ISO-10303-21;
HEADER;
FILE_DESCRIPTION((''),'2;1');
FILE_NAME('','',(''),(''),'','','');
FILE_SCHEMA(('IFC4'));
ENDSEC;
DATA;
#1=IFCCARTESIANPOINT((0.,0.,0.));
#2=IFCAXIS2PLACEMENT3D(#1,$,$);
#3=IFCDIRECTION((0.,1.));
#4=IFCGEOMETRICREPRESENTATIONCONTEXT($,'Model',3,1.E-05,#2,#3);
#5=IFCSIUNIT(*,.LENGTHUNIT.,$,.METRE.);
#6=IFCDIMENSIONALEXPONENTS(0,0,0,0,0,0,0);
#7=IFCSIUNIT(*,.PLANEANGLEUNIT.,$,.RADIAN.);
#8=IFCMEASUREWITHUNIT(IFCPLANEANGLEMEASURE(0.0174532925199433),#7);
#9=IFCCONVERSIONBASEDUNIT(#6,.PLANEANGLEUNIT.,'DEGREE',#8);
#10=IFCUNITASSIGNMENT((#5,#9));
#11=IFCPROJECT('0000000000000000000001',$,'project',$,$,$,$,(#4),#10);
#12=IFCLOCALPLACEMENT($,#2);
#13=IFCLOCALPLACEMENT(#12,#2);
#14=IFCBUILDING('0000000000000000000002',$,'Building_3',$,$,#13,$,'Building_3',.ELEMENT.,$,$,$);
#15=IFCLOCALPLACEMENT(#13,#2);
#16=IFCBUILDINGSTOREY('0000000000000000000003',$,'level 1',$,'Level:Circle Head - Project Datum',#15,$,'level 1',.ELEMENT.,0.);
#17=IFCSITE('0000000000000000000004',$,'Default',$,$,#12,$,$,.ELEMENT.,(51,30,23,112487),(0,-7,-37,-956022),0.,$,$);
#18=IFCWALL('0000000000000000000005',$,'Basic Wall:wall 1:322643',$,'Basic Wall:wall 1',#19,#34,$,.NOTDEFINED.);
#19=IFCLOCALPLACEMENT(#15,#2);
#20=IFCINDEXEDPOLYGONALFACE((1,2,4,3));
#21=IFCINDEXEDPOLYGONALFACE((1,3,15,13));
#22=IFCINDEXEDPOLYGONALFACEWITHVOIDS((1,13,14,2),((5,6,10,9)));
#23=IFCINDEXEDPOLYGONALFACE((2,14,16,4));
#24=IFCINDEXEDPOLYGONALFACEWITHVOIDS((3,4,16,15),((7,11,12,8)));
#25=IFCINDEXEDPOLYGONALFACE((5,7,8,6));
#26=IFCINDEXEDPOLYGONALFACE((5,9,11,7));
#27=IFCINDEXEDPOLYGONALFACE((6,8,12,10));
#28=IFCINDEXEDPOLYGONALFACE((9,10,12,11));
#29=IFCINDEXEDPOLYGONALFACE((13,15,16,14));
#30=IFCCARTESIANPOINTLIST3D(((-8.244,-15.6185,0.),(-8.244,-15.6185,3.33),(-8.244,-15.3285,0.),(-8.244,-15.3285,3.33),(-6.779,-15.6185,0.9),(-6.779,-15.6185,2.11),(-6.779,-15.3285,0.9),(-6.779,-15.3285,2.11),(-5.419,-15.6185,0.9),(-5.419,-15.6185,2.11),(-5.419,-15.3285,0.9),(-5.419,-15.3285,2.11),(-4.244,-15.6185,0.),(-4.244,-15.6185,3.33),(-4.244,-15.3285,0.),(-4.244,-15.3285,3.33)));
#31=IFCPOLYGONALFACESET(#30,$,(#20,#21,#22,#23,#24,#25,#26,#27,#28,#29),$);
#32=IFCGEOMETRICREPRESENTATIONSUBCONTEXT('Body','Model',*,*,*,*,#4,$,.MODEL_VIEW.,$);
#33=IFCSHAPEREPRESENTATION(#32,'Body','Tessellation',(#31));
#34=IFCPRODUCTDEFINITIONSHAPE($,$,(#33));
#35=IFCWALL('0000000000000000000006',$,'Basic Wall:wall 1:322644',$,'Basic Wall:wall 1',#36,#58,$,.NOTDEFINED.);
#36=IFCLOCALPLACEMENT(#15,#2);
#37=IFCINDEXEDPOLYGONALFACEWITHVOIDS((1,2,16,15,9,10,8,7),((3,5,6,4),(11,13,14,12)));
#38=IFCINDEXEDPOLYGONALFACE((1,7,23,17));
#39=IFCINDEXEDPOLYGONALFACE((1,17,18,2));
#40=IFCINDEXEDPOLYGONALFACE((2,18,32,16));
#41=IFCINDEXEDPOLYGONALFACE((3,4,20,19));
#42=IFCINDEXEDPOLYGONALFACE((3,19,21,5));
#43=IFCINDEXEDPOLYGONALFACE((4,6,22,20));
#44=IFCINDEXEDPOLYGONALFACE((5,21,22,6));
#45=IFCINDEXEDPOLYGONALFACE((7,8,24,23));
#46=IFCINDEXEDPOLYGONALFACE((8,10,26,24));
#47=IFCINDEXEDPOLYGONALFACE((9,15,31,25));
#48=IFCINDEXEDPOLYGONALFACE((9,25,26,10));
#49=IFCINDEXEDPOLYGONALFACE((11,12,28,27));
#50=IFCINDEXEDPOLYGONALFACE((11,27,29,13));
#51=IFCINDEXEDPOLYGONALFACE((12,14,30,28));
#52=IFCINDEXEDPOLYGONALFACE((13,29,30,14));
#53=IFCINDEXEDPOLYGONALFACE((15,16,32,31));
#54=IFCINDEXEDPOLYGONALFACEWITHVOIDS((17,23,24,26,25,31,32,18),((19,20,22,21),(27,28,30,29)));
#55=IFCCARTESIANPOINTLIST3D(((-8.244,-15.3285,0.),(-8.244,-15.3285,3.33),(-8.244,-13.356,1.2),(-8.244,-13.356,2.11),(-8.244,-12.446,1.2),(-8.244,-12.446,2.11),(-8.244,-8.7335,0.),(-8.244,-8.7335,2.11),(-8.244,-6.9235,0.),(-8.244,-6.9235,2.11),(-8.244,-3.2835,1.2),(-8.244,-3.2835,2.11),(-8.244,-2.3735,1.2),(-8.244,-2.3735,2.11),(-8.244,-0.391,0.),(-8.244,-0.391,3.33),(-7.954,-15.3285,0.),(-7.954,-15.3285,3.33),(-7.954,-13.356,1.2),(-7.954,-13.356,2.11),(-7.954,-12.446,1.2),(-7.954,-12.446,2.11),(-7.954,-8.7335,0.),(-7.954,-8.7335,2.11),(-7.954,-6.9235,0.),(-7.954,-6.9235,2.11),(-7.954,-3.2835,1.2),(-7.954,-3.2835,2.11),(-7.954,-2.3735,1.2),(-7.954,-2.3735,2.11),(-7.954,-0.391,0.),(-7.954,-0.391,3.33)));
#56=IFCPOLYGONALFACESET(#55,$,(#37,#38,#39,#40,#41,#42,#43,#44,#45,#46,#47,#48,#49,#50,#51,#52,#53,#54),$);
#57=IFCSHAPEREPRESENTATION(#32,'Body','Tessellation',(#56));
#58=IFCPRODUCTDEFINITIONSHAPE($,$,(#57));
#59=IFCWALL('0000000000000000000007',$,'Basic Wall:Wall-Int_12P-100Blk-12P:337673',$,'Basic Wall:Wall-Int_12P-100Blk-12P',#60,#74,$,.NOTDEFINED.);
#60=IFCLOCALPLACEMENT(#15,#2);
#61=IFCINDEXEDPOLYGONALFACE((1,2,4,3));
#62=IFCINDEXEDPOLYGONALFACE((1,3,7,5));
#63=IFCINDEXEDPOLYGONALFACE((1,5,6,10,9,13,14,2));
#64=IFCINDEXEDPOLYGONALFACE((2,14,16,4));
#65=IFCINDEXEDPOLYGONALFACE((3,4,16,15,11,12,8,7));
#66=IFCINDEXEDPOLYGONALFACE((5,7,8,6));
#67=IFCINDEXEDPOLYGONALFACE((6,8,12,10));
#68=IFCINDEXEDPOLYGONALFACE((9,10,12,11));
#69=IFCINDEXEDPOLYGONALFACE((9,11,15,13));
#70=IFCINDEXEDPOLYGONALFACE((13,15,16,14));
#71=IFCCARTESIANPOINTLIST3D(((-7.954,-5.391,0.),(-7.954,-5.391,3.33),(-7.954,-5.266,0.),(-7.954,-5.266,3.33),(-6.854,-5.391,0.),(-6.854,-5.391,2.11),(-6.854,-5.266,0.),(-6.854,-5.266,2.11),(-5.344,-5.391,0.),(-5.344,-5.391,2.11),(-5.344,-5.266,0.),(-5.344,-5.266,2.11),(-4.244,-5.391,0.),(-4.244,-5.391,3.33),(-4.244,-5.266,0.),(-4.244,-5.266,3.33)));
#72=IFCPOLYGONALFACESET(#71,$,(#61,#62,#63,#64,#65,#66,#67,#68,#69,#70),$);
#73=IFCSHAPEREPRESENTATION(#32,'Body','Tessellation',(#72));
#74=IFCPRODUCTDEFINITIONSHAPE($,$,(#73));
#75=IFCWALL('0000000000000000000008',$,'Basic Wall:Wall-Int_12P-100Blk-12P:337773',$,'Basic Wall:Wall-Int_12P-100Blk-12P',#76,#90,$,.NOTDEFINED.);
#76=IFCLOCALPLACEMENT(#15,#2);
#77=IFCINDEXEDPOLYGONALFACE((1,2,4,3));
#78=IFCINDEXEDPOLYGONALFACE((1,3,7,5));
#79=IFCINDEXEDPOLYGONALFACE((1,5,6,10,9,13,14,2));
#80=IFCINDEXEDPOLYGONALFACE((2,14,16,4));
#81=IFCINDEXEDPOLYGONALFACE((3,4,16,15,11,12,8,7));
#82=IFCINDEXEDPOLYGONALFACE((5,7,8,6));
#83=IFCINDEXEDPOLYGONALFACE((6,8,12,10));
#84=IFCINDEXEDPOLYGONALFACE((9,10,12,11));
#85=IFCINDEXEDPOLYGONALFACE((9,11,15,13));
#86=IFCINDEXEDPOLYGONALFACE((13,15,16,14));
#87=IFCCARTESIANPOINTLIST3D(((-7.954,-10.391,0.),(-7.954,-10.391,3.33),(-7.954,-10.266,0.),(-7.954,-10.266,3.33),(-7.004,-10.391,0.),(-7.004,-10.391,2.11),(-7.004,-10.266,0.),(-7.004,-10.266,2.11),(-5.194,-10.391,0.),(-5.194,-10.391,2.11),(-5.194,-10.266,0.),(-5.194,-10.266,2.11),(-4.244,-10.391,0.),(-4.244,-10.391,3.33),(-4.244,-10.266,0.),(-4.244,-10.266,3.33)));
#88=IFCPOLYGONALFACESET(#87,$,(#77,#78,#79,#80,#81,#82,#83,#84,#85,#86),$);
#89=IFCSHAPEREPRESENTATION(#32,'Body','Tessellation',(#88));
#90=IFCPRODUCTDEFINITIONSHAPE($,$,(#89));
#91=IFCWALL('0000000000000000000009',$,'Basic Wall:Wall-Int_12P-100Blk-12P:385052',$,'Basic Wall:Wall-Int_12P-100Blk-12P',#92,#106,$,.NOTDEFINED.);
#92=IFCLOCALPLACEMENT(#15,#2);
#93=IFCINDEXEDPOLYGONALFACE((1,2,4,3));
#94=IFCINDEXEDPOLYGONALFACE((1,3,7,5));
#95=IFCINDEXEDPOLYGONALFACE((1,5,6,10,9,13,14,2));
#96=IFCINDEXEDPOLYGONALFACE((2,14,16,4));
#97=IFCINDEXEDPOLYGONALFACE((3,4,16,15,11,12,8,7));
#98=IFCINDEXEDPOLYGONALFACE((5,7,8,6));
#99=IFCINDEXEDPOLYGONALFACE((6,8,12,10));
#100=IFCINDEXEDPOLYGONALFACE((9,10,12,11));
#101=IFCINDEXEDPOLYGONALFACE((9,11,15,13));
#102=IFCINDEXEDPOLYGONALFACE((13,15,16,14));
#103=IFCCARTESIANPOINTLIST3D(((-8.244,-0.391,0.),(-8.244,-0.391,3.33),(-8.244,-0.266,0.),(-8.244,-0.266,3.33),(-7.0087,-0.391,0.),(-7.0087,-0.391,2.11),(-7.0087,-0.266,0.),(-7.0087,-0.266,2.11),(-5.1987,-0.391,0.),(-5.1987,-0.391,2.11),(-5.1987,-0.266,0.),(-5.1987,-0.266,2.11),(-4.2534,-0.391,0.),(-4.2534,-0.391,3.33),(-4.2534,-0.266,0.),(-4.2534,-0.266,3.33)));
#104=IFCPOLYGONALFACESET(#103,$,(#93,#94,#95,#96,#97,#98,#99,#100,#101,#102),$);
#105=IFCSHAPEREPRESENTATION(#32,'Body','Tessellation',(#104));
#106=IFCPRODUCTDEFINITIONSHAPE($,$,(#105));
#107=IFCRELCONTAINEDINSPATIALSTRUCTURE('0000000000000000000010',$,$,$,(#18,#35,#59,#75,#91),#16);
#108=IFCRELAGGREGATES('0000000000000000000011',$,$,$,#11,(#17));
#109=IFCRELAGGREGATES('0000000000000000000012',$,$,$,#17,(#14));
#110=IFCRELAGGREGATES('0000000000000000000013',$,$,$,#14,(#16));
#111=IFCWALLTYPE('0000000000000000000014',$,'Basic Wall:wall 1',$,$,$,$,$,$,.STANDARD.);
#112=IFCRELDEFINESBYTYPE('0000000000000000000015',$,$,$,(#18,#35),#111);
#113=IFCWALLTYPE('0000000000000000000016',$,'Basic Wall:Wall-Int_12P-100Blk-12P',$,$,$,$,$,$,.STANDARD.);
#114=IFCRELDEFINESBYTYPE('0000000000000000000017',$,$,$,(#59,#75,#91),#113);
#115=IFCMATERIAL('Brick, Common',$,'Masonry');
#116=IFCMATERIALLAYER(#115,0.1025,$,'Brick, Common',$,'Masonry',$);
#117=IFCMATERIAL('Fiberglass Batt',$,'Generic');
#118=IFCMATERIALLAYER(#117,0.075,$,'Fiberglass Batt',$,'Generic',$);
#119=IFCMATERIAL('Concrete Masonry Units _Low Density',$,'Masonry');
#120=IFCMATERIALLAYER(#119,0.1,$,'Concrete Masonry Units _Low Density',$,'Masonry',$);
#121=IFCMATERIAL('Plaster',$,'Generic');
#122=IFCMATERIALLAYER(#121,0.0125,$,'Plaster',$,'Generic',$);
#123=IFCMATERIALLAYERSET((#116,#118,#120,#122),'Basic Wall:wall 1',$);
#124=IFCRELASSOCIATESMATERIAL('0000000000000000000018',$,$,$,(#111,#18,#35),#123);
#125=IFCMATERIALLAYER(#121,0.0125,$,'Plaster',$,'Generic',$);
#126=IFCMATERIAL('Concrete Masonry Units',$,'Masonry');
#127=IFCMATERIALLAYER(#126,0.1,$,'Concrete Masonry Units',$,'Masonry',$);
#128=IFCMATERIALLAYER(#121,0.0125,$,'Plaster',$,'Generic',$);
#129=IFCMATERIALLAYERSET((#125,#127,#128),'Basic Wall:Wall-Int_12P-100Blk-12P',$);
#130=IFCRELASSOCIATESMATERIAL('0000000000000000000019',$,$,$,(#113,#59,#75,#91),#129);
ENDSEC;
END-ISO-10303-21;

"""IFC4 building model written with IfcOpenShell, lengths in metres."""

from ifc_helpers import new_model, entity, si_unit, converted_unit, direction, frame, frame_2d, origin, place, context, subcontext, project, spatial, polyline, rectangle, extrude, clip, bounded_halfspace, material, layer, layer_set, layer_usage, type_object, element, save


model = new_model("IFC4")

# Units and contexts
model_context = context("Model", 3, precision=1e-05, world=origin(), true_north=direction((0.0, 1.0)))
body_context = subcontext(model_context, "Body", "Model", "MODEL_VIEW")
ifc_project = project(units=[si_unit("LENGTHUNIT", "METRE"), converted_unit("PLANEANGLEUNIT", "DEGREE", entity("IfcPlaneAngleMeasure", 0.0174532925199433), si_unit("PLANEANGLEUNIT", "RADIAN"), dimensions=[0, 0, 0, 0, 0, 0, 0])], contexts=[model_context])

# Site, building, storey
site_placement = place(None, origin())
site = spatial("IfcSite", under=ifc_project, at=site_placement, Name="Default", CompositionType="ELEMENT", RefLatitude=(51, 30, 23, 112487), RefLongitude=(0, -7, -37, -956022), RefElevation=0.0)
building_placement = place(site_placement, origin())
building = spatial("IfcBuilding", under=site, at=building_placement, Name="Building_3", LongName="Building_3", CompositionType="ELEMENT")
storey_placement = place(building_placement, origin())
storey = spatial("IfcBuildingStorey", under=building, at=storey_placement, Name="level 1", ObjectType="Level:Circle Head - Project Datum", LongName="level 1", CompositionType="ELEMENT", Elevation=0.0)

# Shared definitions
ifc_material_1 = material(Name="Brick, Common", Category="Masonry")
ifc_layer_1 = layer(ifc_material_1, 0.1025, Name="Brick, Common", Category="Masonry")
ifc_material_2 = material(Name="Fiberglass Batt", Category="Generic")
ifc_layer_2 = layer(ifc_material_2, 0.075, Name="Fiberglass Batt", Category="Generic")
ifc_material_3 = material(Name="Concrete Masonry Units _Low Density", Category="Masonry")
ifc_layer_3 = layer(ifc_material_3, 0.1, Name="Concrete Masonry Units _Low Density", Category="Masonry")
ifc_material_4 = material(Name="Plaster", Category="Generic")
ifc_layer_4 = layer(ifc_material_4, 0.0125, Name="Plaster", Category="Generic")
ifc_layer_set_1 = layer_set([ifc_layer_1, ifc_layer_2, ifc_layer_3, ifc_layer_4], Name="Basic Wall:wall 1")
wall_type_1 = type_object("IfcWallType", Name="Basic Wall:wall 1", PredefinedType="STANDARD", material=ifc_layer_set_1)

# Wall, opening
ifc_layer_usage_1 = layer_usage(ifc_layer_set_1, "AXIS2", "NEGATIVE", 0.145)
wall_1_placement = place(storey_placement, frame((-4.244, -15.4735, 0.0), z_axis=(0.0, 0.0, 1.0), x_axis=(-1.0, 0.0, 0.0)))
wall_1 = element("IfcWall", 1, at=wall_1_placement, inside=storey, type_object=wall_type_1, material=ifc_layer_usage_1, Name="Basic Wall:wall 1:322643", ObjectType="Basic Wall:wall 1", PredefinedType="NOTDEFINED", context=body_context, shape_type="Clipping", body=[
    clip(extrude(rectangle(XDim=4.0, YDim=0.29, at=frame_2d((2.0, 0.0), x_axis=(-1.0, 0.0))), origin(), (0.0, 0.0, 1.0), 3.33), bounded_halfspace(frame((0.0, -0.145, 3.33), z_axis=(0.0, 0.0, -1.0), x_axis=(0.0, -1.0, 0.0)), True, frame((0.0, -0.145, 3.33)), polyline([(0.0, 0.0), (3.71, 0.0), (4.0, 0.0), (4.0, 0.29), (0.0, 0.29), (0.0, 0.0)]))),
])
opening_1_placement = place(wall_1_placement, frame((1.175, -0.145, 0.9)))
element("IfcOpeningElement", 2, at=opening_1_placement, cuts=wall_1, PredefinedType="OPENING", context=body_context, shape_type="SweptSolid", body=[
    extrude(rectangle(XDim=1.21, YDim=1.36, at=frame_2d((0.605, 0.68), x_axis=(-1.0, 0.0))), frame((0.0, 0.0, 0.0), z_axis=(0.0, 1.0, 0.0), x_axis=(0.0, 0.0, 1.0)), (0.0, 0.0, 1.0), 0.29),
])

# Wall, openings
ifc_layer_usage_2 = layer_usage(ifc_layer_set_1, "AXIS2", "NEGATIVE", 0.145)
wall_2_placement = place(storey_placement, frame((-8.099, -15.3285, 0.0), z_axis=(0.0, 0.0, 1.0), x_axis=(0.0, 1.0, 0.0)))
wall_2 = element("IfcWall", 3, at=wall_2_placement, inside=storey, type_object=wall_type_1, material=ifc_layer_usage_2, Name="Basic Wall:wall 1:322644", ObjectType="Basic Wall:wall 1", PredefinedType="NOTDEFINED", context=body_context, shape_type="Clipping", body=[
    clip(extrude(rectangle(XDim=14.9375, YDim=0.29, at=frame_2d((7.4688, 0.0), x_axis=(1.0, 0.0))), origin(), (0.0, 0.0, 1.0), 3.33), bounded_halfspace(frame((0.0, -0.145, 3.33), z_axis=(0.0, 0.0, -1.0), x_axis=(1.0, 0.0, 0.0)), True, frame((0.0, -0.145, 3.33)), polyline([(0.0, 0.0), (4.9375, 0.0), (5.0625, 0.0), (9.9375, 0.0), (10.0625, 0.0), (14.9375, 0.0), (14.9375, 0.29), (0.0, 0.29), (0.0, 0.0)]))),
])
opening_2_placement = place(wall_2_placement, frame((8.405, 0.145, 0.0)))
element("IfcOpeningElement", 4, at=opening_2_placement, cuts=wall_2, PredefinedType="OPENING", context=body_context, shape_type="SweptSolid", body=[
    extrude(rectangle(XDim=2.11, YDim=1.81, at=frame_2d((1.055, 0.905), x_axis=(-1.0, 0.0))), frame((0.0, 0.0, 0.0), z_axis=(0.0, -1.0, 0.0), x_axis=(0.0, 0.0, 1.0)), (0.0, 0.0, 1.0), 0.29),
])
opening_3_placement = place(wall_2_placement, frame((1.9725, -0.145, 1.2)))
element("IfcOpeningElement", 5, at=opening_3_placement, cuts=wall_2, PredefinedType="OPENING", context=body_context, shape_type="SweptSolid", body=[
    extrude(rectangle(XDim=0.91, YDim=0.91, at=frame_2d((0.455, 0.455), x_axis=(-1.0, 0.0))), frame((0.0, 0.0, 0.0), z_axis=(0.0, 1.0, 0.0), x_axis=(0.0, 0.0, 1.0)), (0.0, 0.0, 1.0), 0.29),
])
opening_4_placement = place(wall_2_placement, frame((12.045, -0.145, 1.2)))
element("IfcOpeningElement", 6, at=opening_4_placement, cuts=wall_2, PredefinedType="OPENING", context=body_context, shape_type="SweptSolid", body=[
    extrude(rectangle(XDim=0.91, YDim=0.91, at=frame_2d((0.455, 0.455), x_axis=(-1.0, 0.0))), frame((0.0, 0.0, 0.0), z_axis=(0.0, 1.0, 0.0), x_axis=(0.0, 0.0, 1.0)), (0.0, 0.0, 1.0), 0.29),
])

# Walls, openings
ifc_layer_5 = layer(ifc_material_4, 0.0125, Name="Plaster", Category="Generic")
ifc_material_5 = material(Name="Concrete Masonry Units", Category="Masonry")
ifc_layer_6 = layer(ifc_material_5, 0.1, Name="Concrete Masonry Units", Category="Masonry")
ifc_layer_7 = layer(ifc_material_4, 0.0125, Name="Plaster", Category="Generic")
ifc_layer_set_2 = layer_set([ifc_layer_5, ifc_layer_6, ifc_layer_7], Name="Basic Wall:Wall-Int_12P-100Blk-12P")
ifc_layer_usage_3 = layer_usage(ifc_layer_set_2, "AXIS2", "NEGATIVE", 0.0625)
wall_type_2 = type_object("IfcWallType", Name="Basic Wall:Wall-Int_12P-100Blk-12P", PredefinedType="STANDARD", material=ifc_layer_set_2)
wall_3_placement = place(storey_placement, frame((-7.954, -5.3285, 0.0)))
wall_3 = element("IfcWall", 7, at=wall_3_placement, inside=storey, type_object=wall_type_2, material=ifc_layer_usage_3, Name="Basic Wall:Wall-Int_12P-100Blk-12P:337673", ObjectType="Basic Wall:Wall-Int_12P-100Blk-12P", PredefinedType="NOTDEFINED", context=body_context, shape_type="Clipping", body=[
    clip(extrude(rectangle(XDim=3.71, YDim=0.125, at=frame_2d((1.855, 0.0), x_axis=(1.0, 0.0))), origin(), (0.0, 0.0, 1.0), 3.33), bounded_halfspace(frame((0.0, -0.0625, 3.33), z_axis=(0.0, 0.0, -1.0), x_axis=(0.0, 1.0, 0.0)), True, frame((0.0, -0.0625, 3.33)), polyline([(0.0, 0.0), (3.71, 0.0), (3.71, 0.125), (0.0, 0.125), (0.0, 0.0)]))),
])
opening_5_placement = place(wall_3_placement, frame((1.1, -0.0625, 0.0)))
element("IfcOpeningElement", 8, at=opening_5_placement, cuts=wall_3, PredefinedType="OPENING", context=body_context, shape_type="SweptSolid", body=[
    extrude(rectangle(XDim=2.11, YDim=1.51, at=frame_2d((1.055, 0.755), x_axis=(-1.0, 0.0))), frame((0.0, 0.0, 0.0), z_axis=(0.0, 1.0, 0.0), x_axis=(0.0, 0.0, 1.0)), (0.0, 0.0, 1.0), 0.125),
])
ifc_layer_usage_4 = layer_usage(ifc_layer_set_2, "AXIS2", "NEGATIVE", 0.0625)
wall_4_placement = place(storey_placement, frame((-7.954, -10.3285, 0.0)))
wall_4 = element("IfcWall", 9, at=wall_4_placement, inside=storey, type_object=wall_type_2, material=ifc_layer_usage_4, Name="Basic Wall:Wall-Int_12P-100Blk-12P:337773", ObjectType="Basic Wall:Wall-Int_12P-100Blk-12P", PredefinedType="NOTDEFINED", context=body_context, shape_type="Clipping", body=[
    clip(extrude(rectangle(XDim=3.71, YDim=0.125, at=frame_2d((1.855, 0.0), x_axis=(-1.0, 0.0))), origin(), (0.0, 0.0, 1.0), 3.33), bounded_halfspace(frame((0.0, -0.0625, 3.33), z_axis=(0.0, 0.0, -1.0), x_axis=(0.0, 1.0, 0.0)), True, frame((0.0, -0.0625, 3.33)), polyline([(0.0, 0.0), (3.71, 0.0), (3.71, 0.125), (0.0, 0.125), (0.0, 0.0)]))),
])
opening_6_placement = place(wall_4_placement, frame((0.95, -0.0625, 0.0)))
element("IfcOpeningElement", 10, at=opening_6_placement, cuts=wall_4, PredefinedType="OPENING", context=body_context, shape_type="SweptSolid", body=[
    extrude(rectangle(XDim=2.11, YDim=1.81, at=frame_2d((1.055, 0.905), x_axis=(-1.0, 0.0))), frame((0.0, 0.0, 0.0), z_axis=(0.0, 1.0, 0.0), x_axis=(0.0, 0.0, 1.0)), (0.0, 0.0, 1.0), 0.125),
])

# Wall, openings
ifc_layer_usage_5 = layer_usage(ifc_layer_set_2, "AXIS2", "NEGATIVE", 0.0625)
wall_5_placement = place(storey_placement, frame((-4.2534, -0.3285, 0.0), z_axis=(0.0, 0.0, 1.0), x_axis=(-1.0, 0.0, 0.0)))
wall_5 = element("IfcWall", 11, at=wall_5_placement, inside=storey, type_object=wall_type_2, material=ifc_layer_usage_5, Name="Basic Wall:Wall-Int_12P-100Blk-12P:385052", ObjectType="Basic Wall:Wall-Int_12P-100Blk-12P", PredefinedType="NOTDEFINED", context=body_context, shape_type="Clipping", body=[
    clip(extrude(rectangle(XDim=3.9906, YDim=0.125, at=frame_2d((1.9953, 0.0), x_axis=(-1.0, 0.0))), origin(), (0.0, 0.0, 1.0), 3.33), bounded_halfspace(frame((0.0, -0.0625, 3.33), z_axis=(0.0, 0.0, -1.0), x_axis=(0.0, -1.0, 0.0)), True, frame((0.0, -0.0625, 3.33)), polyline([(0.0, 0.0), (3.7006, 0.0), (3.9906, 0.0), (3.9906, 0.125), (3.7006, 0.125), (0.0, 0.125), (0.0, 0.0)]))),
])
opening_7_placement = place(wall_5_placement, frame((2.7553, 0.0625, 0.0)))
element("IfcOpeningElement", 12, at=opening_7_placement, cuts=wall_5, PredefinedType="OPENING", context=body_context, shape_type="SweptSolid", body=[
    extrude(rectangle(XDim=2.11, YDim=1.81, at=frame_2d((1.055, 0.905), x_axis=(-1.0, 0.0))), frame((0.0, 0.0, 0.0), z_axis=(0.0, -1.0, 0.0), x_axis=(0.0, 0.0, 1.0)), (0.0, 0.0, 1.0), 0.125),
])
opening_8_placement = place(wall_5_placement, frame((-4.2534, -0.3285, 0.0), z_axis=(0.0, 0.0, 1.0), x_axis=(-1.0, 0.0, 0.0)))
element("IfcOpeningElement", 13, at=opening_8_placement, cuts=wall_5, PredefinedType="OPENING", context=body_context, shape_type="SweptSolid", body=[
    extrude(rectangle(XDim=2.11, YDim=1.81, at=frame_2d((0.0, 0.0), x_axis=(0.0, 1.0))), frame((-6.1037, 1.258, 1.055), z_axis=(0.0, -1.0, 0.0), x_axis=(-1.0, 0.0, 0.0)), (0.0, 0.0, 1.0), 3.048),
])

save(model, "model.ifc")
